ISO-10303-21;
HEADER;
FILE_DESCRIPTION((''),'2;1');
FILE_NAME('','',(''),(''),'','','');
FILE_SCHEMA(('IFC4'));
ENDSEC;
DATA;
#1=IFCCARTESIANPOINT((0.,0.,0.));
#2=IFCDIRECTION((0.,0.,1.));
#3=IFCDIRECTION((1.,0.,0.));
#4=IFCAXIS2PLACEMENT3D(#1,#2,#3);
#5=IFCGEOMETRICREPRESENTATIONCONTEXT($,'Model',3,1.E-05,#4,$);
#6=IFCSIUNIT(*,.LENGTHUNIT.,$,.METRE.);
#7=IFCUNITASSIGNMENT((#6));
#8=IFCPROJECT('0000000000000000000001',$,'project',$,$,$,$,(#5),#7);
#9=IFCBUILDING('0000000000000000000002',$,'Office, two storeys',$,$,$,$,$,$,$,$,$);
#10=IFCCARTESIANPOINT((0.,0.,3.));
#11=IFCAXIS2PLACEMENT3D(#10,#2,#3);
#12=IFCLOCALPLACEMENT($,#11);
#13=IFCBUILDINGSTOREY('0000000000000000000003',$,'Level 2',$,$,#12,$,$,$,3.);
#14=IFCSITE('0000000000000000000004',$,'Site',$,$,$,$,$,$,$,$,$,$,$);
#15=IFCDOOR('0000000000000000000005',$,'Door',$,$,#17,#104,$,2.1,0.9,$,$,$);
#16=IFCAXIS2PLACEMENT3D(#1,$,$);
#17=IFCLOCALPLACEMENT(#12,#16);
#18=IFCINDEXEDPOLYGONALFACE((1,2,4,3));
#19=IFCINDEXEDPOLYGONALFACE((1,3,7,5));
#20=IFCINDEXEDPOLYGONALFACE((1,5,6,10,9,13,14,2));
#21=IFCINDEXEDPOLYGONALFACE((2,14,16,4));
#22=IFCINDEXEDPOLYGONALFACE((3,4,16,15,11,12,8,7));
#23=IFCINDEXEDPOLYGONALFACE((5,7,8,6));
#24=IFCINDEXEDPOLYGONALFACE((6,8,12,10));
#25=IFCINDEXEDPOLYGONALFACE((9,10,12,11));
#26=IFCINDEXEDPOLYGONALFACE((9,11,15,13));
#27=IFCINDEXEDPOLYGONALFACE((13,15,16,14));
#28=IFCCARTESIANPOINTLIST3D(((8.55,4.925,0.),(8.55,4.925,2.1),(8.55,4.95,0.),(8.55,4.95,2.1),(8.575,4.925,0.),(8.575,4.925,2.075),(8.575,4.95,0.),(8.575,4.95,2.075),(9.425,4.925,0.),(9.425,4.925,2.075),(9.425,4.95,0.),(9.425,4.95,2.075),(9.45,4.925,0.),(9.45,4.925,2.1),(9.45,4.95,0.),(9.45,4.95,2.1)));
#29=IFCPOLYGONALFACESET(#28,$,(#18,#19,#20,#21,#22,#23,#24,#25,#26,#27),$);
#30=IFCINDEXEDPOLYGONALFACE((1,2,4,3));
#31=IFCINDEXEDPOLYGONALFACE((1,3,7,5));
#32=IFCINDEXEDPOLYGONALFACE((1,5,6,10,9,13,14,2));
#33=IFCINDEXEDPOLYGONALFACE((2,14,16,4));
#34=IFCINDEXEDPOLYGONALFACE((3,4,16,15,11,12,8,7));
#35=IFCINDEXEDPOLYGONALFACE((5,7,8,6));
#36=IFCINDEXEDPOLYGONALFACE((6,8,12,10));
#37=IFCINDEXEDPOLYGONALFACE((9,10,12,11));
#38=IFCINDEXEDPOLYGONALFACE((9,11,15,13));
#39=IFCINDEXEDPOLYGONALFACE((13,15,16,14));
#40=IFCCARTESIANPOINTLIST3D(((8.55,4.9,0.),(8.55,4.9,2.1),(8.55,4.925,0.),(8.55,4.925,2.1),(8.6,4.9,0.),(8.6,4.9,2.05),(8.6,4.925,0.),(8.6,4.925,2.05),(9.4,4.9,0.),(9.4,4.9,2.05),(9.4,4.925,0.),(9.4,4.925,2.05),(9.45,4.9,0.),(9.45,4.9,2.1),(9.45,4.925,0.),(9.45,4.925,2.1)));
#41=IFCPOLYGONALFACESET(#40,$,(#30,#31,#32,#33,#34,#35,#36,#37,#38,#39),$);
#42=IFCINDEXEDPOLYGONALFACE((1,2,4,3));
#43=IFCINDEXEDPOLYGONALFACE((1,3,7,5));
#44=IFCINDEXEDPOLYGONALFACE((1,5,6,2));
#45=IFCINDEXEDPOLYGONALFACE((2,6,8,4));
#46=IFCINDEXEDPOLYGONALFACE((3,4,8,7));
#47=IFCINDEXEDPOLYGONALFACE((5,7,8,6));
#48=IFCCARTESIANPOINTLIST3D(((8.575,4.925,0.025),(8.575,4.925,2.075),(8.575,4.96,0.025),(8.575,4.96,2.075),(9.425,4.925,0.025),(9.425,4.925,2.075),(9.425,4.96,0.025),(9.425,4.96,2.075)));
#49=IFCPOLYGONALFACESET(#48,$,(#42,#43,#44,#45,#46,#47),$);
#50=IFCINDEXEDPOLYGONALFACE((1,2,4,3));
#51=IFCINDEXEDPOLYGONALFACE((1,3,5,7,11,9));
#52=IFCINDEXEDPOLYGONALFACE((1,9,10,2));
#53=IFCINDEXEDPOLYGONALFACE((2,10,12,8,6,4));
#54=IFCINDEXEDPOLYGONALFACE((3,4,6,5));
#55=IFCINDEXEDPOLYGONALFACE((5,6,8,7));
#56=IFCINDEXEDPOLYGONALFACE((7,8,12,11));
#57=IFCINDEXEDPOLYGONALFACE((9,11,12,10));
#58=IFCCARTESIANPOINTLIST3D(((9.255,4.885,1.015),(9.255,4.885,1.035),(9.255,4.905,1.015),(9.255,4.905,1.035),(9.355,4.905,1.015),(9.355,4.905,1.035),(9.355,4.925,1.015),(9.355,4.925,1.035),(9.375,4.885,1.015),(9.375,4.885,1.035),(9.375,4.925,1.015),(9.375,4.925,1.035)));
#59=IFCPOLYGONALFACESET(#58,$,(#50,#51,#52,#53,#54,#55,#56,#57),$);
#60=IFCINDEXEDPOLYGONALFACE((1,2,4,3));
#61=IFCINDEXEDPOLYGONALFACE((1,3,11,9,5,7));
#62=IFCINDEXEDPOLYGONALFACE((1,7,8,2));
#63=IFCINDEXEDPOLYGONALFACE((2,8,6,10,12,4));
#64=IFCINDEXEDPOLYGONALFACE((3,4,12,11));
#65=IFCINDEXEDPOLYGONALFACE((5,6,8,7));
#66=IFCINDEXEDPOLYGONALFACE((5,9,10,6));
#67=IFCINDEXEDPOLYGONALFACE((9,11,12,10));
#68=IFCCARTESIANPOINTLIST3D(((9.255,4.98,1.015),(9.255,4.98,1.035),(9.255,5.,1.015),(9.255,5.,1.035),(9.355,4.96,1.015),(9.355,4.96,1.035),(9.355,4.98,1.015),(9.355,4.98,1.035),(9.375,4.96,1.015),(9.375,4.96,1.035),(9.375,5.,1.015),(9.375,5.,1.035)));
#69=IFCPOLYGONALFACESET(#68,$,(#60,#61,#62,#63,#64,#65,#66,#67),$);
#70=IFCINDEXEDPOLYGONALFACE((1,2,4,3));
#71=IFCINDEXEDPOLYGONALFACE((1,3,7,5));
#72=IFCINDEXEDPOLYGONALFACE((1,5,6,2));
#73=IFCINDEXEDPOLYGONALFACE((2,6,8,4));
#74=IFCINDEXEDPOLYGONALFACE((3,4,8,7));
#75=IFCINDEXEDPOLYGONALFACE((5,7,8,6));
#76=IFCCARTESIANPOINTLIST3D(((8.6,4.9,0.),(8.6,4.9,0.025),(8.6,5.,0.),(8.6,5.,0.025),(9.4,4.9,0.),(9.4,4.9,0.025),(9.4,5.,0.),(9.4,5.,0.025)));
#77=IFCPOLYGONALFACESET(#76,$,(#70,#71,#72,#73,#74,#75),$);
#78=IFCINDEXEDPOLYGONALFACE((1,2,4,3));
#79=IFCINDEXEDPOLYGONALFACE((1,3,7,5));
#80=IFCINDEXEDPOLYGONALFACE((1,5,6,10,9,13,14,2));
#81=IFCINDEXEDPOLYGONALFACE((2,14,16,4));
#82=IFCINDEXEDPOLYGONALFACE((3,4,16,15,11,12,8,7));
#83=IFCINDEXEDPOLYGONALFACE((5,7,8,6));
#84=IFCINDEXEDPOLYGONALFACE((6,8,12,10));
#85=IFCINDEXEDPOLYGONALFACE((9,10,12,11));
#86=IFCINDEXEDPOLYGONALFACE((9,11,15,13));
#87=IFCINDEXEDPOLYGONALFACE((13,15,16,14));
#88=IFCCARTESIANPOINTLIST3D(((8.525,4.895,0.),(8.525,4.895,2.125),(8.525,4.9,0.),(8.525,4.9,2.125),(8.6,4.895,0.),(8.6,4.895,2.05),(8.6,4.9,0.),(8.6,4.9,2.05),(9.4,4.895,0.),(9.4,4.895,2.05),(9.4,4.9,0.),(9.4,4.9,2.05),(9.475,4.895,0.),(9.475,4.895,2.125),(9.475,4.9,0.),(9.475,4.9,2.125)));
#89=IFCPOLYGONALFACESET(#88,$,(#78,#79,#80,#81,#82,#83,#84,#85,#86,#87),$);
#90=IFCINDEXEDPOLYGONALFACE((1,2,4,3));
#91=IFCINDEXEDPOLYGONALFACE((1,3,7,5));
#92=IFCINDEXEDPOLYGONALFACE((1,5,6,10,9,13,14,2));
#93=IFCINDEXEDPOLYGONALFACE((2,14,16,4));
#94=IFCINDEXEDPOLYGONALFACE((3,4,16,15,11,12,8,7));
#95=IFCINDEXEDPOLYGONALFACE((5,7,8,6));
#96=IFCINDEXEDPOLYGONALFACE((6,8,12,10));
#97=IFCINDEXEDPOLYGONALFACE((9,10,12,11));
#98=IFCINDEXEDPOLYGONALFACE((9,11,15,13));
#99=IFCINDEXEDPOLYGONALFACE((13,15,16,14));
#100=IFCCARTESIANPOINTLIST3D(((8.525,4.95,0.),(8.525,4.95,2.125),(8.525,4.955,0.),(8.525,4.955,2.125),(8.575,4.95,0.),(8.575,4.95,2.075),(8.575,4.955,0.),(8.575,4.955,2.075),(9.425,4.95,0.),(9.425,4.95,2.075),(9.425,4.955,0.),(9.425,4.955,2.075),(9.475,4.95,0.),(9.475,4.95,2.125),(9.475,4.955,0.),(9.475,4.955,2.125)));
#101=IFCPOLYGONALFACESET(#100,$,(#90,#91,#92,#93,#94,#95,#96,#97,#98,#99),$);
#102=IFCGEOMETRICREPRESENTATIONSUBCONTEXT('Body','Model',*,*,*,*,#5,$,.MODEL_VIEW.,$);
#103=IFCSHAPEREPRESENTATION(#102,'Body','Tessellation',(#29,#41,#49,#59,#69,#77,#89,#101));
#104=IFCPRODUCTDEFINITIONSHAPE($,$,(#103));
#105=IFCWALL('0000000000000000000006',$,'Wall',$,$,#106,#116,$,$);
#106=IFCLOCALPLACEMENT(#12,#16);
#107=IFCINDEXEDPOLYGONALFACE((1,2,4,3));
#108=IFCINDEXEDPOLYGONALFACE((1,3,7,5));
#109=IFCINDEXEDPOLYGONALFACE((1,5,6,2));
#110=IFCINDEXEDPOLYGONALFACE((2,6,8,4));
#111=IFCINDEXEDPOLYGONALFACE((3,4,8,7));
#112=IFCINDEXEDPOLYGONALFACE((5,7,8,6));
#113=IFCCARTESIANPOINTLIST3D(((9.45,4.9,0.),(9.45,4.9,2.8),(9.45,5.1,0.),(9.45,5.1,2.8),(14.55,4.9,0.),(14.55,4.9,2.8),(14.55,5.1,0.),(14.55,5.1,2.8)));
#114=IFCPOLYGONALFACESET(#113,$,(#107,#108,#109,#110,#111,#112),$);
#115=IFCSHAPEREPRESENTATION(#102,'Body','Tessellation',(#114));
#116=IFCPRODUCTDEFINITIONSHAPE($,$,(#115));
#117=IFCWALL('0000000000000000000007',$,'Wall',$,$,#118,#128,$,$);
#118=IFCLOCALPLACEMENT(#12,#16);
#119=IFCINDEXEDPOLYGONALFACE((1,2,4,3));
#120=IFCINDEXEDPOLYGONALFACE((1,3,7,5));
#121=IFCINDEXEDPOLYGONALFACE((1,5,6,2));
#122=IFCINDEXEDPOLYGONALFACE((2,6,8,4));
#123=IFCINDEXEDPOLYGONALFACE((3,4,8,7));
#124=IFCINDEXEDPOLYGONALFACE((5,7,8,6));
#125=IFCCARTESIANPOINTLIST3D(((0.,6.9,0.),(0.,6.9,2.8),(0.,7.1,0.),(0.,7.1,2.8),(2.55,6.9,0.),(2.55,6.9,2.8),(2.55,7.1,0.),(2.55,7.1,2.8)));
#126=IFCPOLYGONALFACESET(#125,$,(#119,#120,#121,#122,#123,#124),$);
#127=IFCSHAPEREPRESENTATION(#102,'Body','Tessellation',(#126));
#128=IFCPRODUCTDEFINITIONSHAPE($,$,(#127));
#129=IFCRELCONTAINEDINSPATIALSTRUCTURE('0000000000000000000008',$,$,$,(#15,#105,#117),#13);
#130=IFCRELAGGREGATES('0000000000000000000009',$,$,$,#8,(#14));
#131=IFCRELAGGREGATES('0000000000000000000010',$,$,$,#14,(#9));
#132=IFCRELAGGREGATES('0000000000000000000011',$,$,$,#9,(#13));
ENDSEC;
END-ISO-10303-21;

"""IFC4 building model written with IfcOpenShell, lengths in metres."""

from ifc_helpers import new_model, si_unit, frame, origin_with_axes, place, context, subcontext, project, spatial, line, indexed_curve, outline, extrude, element, save


model = new_model("IFC4")

# Units and contexts
model_context = context("Model", 3, precision=1e-05, world=origin_with_axes())
body_context = subcontext(model_context, "Body", "Model", "MODEL_VIEW")
ifc_project = project(units=[si_unit("LENGTHUNIT", "METRE")], contexts=[model_context])

# Site, building, storey
site = spatial("IfcSite", under=ifc_project, Name="Site")
building = spatial("IfcBuilding", under=site, Name="Office, two storeys")
storey_placement = place(None, frame((0.0, 0.0, 3.0), z_axis=(0.0, 0.0, 1.0), x_axis=(1.0, 0.0, 0.0)))
storey = spatial("IfcBuildingStorey", under=building, at=storey_placement, Name="Level 2", Elevation=3.0)

# Door
door_1_placement = place(storey_placement, frame((8.55, 4.9, 0.0), z_axis=(0.0, 0.0, 1.0), x_axis=(1.0, 0.0, 0.0)))
element("IfcDoor", 1, at=door_1_placement, inside=storey, Name="Door", OverallHeight=2.1, OverallWidth=0.9, context=body_context, shape_type="SweptSolid", body=[
    extrude(outline(indexed_curve([(0.0, 0.0), (0.0, 2.1), (0.9, 2.1), (0.9, 0.0), (0.875, 0.0), (0.875, 2.075), (0.025, 2.075), (0.025, 0.0)], segments=[line(1, 2, 3, 4, 5, 6, 7, 8, 1)])), frame((0.0, 0.025, 0.0), z_axis=(0.0, -1.0, 0.0), x_axis=(1.0, 0.0, 0.0)), (0.0, 0.0, -1.0), 0.025),
    extrude(outline(indexed_curve([(0.0, 0.0), (0.0, 2.1), (0.9, 2.1), (0.9, 0.0), (0.85, 0.0), (0.85, 2.05), (0.05, 2.05), (0.05, 0.0)], segments=[line(1, 2, 3, 4, 5, 6, 7, 8, 1)])), frame((0.0, 0.0, 0.0), z_axis=(0.0, -1.0, 0.0), x_axis=(1.0, 0.0, 0.0)), (0.0, 0.0, -1.0), 0.025),
    extrude(outline(indexed_curve([(0.0, 0.0), (0.85, 0.0), (0.85, 0.035), (0.0, 0.035)], segments=[line(1, 2, 3, 4, 1)])), frame((0.025, 0.025, 0.025), z_axis=(0.0, 0.0, 1.0), x_axis=(1.0, 0.0, 0.0)), (0.0, 0.0, 1.0), 2.05),
    extrude(outline(indexed_curve([(0.0, 0.0), (0.0, -0.04), (-0.12, -0.04), (-0.12, -0.02), (-0.02, -0.02), (-0.02, 0.0)], segments=[line(1, 2, 3, 4, 5, 6, 1)])), frame((0.825, 0.025, 1.015), z_axis=(0.0, 0.0, 1.0), x_axis=(1.0, 0.0, 0.0)), (0.0, 0.0, 1.0), 0.02),
    extrude(outline(indexed_curve([(0.0, 0.0), (0.0, 0.04), (-0.12, 0.04), (-0.12, 0.02), (-0.02, 0.02), (-0.02, 0.0)], segments=[line(1, 2, 3, 4, 5, 6, 1)])), frame((0.825, 0.06, 1.015), z_axis=(0.0, 0.0, 1.0), x_axis=(1.0, 0.0, 0.0)), (0.0, 0.0, 1.0), 0.02),
    extrude(outline(indexed_curve([(0.0, 0.0), (0.8, 0.0), (0.8, 0.1), (0.0, 0.1)], segments=[line(1, 2, 3, 4, 1)])), frame((0.05, 0.0, 0.0), z_axis=(0.0, 0.0, 1.0), x_axis=(1.0, 0.0, 0.0)), (0.0, 0.0, 1.0), 0.025),
    extrude(outline(indexed_curve([(0.0, 0.0), (0.0, 2.125), (0.95, 2.125), (0.95, 0.0), (0.875, 0.0), (0.875, 2.05), (0.075, 2.05), (0.075, 0.0)], segments=[line(1, 2, 3, 4, 5, 6, 7, 8, 1)])), frame((-0.025, -0.005, 0.0), z_axis=(0.0, -1.0, 0.0), x_axis=(1.0, 0.0, 0.0)), (0.0, 0.0, -1.0), 0.005),
    extrude(outline(indexed_curve([(0.0, 0.0), (0.0, 2.125), (0.95, 2.125), (0.95, 0.0), (0.9, 0.0), (0.9, 2.075), (0.05, 2.075), (0.05, 0.0)], segments=[line(1, 2, 3, 4, 5, 6, 7, 8, 1)])), frame((-0.025, 0.05, 0.0), z_axis=(0.0, -1.0, 0.0), x_axis=(1.0, 0.0, 0.0)), (0.0, 0.0, -1.0), 0.005),
])

# Walls
wall_1_placement = place(storey_placement, frame((9.45, 5.0, 0.0), z_axis=(0.0, 0.0, 1.0), x_axis=(1.0, 0.0, 0.0)))
element("IfcWall", 2, at=wall_1_placement, inside=storey, Name="Wall", context=body_context, shape_type="SweptSolid", body=[
    extrude(outline(indexed_curve([(0.0, 0.0), (0.0, 0.2), (5.1, 0.2), (5.1, 0.0), (0.0, 0.0)], self_intersect=False)), frame((0.0, -0.1, 0.0), z_axis=(0.0, 0.0, 1.0), x_axis=(1.0, 0.0, 0.0)), (0.0, 0.0, 1.0), 2.8),
])
wall_2_placement = place(storey_placement, frame((0.0, 7.0, 0.0), z_axis=(0.0, 0.0, 1.0), x_axis=(1.0, 0.0, 0.0)))
element("IfcWall", 3, at=wall_2_placement, inside=storey, Name="Wall", context=body_context, shape_type="SweptSolid", body=[
    extrude(outline(indexed_curve([(0.0, 0.0), (0.0, 0.2), (2.55, 0.2), (2.55, 0.0), (0.0, 0.0)], self_intersect=False)), frame((0.0, -0.1, 0.0), z_axis=(0.0, 0.0, 1.0), x_axis=(1.0, 0.0, 0.0)), (0.0, 0.0, 1.0), 2.8),
])

save(model, "model.ifc")
